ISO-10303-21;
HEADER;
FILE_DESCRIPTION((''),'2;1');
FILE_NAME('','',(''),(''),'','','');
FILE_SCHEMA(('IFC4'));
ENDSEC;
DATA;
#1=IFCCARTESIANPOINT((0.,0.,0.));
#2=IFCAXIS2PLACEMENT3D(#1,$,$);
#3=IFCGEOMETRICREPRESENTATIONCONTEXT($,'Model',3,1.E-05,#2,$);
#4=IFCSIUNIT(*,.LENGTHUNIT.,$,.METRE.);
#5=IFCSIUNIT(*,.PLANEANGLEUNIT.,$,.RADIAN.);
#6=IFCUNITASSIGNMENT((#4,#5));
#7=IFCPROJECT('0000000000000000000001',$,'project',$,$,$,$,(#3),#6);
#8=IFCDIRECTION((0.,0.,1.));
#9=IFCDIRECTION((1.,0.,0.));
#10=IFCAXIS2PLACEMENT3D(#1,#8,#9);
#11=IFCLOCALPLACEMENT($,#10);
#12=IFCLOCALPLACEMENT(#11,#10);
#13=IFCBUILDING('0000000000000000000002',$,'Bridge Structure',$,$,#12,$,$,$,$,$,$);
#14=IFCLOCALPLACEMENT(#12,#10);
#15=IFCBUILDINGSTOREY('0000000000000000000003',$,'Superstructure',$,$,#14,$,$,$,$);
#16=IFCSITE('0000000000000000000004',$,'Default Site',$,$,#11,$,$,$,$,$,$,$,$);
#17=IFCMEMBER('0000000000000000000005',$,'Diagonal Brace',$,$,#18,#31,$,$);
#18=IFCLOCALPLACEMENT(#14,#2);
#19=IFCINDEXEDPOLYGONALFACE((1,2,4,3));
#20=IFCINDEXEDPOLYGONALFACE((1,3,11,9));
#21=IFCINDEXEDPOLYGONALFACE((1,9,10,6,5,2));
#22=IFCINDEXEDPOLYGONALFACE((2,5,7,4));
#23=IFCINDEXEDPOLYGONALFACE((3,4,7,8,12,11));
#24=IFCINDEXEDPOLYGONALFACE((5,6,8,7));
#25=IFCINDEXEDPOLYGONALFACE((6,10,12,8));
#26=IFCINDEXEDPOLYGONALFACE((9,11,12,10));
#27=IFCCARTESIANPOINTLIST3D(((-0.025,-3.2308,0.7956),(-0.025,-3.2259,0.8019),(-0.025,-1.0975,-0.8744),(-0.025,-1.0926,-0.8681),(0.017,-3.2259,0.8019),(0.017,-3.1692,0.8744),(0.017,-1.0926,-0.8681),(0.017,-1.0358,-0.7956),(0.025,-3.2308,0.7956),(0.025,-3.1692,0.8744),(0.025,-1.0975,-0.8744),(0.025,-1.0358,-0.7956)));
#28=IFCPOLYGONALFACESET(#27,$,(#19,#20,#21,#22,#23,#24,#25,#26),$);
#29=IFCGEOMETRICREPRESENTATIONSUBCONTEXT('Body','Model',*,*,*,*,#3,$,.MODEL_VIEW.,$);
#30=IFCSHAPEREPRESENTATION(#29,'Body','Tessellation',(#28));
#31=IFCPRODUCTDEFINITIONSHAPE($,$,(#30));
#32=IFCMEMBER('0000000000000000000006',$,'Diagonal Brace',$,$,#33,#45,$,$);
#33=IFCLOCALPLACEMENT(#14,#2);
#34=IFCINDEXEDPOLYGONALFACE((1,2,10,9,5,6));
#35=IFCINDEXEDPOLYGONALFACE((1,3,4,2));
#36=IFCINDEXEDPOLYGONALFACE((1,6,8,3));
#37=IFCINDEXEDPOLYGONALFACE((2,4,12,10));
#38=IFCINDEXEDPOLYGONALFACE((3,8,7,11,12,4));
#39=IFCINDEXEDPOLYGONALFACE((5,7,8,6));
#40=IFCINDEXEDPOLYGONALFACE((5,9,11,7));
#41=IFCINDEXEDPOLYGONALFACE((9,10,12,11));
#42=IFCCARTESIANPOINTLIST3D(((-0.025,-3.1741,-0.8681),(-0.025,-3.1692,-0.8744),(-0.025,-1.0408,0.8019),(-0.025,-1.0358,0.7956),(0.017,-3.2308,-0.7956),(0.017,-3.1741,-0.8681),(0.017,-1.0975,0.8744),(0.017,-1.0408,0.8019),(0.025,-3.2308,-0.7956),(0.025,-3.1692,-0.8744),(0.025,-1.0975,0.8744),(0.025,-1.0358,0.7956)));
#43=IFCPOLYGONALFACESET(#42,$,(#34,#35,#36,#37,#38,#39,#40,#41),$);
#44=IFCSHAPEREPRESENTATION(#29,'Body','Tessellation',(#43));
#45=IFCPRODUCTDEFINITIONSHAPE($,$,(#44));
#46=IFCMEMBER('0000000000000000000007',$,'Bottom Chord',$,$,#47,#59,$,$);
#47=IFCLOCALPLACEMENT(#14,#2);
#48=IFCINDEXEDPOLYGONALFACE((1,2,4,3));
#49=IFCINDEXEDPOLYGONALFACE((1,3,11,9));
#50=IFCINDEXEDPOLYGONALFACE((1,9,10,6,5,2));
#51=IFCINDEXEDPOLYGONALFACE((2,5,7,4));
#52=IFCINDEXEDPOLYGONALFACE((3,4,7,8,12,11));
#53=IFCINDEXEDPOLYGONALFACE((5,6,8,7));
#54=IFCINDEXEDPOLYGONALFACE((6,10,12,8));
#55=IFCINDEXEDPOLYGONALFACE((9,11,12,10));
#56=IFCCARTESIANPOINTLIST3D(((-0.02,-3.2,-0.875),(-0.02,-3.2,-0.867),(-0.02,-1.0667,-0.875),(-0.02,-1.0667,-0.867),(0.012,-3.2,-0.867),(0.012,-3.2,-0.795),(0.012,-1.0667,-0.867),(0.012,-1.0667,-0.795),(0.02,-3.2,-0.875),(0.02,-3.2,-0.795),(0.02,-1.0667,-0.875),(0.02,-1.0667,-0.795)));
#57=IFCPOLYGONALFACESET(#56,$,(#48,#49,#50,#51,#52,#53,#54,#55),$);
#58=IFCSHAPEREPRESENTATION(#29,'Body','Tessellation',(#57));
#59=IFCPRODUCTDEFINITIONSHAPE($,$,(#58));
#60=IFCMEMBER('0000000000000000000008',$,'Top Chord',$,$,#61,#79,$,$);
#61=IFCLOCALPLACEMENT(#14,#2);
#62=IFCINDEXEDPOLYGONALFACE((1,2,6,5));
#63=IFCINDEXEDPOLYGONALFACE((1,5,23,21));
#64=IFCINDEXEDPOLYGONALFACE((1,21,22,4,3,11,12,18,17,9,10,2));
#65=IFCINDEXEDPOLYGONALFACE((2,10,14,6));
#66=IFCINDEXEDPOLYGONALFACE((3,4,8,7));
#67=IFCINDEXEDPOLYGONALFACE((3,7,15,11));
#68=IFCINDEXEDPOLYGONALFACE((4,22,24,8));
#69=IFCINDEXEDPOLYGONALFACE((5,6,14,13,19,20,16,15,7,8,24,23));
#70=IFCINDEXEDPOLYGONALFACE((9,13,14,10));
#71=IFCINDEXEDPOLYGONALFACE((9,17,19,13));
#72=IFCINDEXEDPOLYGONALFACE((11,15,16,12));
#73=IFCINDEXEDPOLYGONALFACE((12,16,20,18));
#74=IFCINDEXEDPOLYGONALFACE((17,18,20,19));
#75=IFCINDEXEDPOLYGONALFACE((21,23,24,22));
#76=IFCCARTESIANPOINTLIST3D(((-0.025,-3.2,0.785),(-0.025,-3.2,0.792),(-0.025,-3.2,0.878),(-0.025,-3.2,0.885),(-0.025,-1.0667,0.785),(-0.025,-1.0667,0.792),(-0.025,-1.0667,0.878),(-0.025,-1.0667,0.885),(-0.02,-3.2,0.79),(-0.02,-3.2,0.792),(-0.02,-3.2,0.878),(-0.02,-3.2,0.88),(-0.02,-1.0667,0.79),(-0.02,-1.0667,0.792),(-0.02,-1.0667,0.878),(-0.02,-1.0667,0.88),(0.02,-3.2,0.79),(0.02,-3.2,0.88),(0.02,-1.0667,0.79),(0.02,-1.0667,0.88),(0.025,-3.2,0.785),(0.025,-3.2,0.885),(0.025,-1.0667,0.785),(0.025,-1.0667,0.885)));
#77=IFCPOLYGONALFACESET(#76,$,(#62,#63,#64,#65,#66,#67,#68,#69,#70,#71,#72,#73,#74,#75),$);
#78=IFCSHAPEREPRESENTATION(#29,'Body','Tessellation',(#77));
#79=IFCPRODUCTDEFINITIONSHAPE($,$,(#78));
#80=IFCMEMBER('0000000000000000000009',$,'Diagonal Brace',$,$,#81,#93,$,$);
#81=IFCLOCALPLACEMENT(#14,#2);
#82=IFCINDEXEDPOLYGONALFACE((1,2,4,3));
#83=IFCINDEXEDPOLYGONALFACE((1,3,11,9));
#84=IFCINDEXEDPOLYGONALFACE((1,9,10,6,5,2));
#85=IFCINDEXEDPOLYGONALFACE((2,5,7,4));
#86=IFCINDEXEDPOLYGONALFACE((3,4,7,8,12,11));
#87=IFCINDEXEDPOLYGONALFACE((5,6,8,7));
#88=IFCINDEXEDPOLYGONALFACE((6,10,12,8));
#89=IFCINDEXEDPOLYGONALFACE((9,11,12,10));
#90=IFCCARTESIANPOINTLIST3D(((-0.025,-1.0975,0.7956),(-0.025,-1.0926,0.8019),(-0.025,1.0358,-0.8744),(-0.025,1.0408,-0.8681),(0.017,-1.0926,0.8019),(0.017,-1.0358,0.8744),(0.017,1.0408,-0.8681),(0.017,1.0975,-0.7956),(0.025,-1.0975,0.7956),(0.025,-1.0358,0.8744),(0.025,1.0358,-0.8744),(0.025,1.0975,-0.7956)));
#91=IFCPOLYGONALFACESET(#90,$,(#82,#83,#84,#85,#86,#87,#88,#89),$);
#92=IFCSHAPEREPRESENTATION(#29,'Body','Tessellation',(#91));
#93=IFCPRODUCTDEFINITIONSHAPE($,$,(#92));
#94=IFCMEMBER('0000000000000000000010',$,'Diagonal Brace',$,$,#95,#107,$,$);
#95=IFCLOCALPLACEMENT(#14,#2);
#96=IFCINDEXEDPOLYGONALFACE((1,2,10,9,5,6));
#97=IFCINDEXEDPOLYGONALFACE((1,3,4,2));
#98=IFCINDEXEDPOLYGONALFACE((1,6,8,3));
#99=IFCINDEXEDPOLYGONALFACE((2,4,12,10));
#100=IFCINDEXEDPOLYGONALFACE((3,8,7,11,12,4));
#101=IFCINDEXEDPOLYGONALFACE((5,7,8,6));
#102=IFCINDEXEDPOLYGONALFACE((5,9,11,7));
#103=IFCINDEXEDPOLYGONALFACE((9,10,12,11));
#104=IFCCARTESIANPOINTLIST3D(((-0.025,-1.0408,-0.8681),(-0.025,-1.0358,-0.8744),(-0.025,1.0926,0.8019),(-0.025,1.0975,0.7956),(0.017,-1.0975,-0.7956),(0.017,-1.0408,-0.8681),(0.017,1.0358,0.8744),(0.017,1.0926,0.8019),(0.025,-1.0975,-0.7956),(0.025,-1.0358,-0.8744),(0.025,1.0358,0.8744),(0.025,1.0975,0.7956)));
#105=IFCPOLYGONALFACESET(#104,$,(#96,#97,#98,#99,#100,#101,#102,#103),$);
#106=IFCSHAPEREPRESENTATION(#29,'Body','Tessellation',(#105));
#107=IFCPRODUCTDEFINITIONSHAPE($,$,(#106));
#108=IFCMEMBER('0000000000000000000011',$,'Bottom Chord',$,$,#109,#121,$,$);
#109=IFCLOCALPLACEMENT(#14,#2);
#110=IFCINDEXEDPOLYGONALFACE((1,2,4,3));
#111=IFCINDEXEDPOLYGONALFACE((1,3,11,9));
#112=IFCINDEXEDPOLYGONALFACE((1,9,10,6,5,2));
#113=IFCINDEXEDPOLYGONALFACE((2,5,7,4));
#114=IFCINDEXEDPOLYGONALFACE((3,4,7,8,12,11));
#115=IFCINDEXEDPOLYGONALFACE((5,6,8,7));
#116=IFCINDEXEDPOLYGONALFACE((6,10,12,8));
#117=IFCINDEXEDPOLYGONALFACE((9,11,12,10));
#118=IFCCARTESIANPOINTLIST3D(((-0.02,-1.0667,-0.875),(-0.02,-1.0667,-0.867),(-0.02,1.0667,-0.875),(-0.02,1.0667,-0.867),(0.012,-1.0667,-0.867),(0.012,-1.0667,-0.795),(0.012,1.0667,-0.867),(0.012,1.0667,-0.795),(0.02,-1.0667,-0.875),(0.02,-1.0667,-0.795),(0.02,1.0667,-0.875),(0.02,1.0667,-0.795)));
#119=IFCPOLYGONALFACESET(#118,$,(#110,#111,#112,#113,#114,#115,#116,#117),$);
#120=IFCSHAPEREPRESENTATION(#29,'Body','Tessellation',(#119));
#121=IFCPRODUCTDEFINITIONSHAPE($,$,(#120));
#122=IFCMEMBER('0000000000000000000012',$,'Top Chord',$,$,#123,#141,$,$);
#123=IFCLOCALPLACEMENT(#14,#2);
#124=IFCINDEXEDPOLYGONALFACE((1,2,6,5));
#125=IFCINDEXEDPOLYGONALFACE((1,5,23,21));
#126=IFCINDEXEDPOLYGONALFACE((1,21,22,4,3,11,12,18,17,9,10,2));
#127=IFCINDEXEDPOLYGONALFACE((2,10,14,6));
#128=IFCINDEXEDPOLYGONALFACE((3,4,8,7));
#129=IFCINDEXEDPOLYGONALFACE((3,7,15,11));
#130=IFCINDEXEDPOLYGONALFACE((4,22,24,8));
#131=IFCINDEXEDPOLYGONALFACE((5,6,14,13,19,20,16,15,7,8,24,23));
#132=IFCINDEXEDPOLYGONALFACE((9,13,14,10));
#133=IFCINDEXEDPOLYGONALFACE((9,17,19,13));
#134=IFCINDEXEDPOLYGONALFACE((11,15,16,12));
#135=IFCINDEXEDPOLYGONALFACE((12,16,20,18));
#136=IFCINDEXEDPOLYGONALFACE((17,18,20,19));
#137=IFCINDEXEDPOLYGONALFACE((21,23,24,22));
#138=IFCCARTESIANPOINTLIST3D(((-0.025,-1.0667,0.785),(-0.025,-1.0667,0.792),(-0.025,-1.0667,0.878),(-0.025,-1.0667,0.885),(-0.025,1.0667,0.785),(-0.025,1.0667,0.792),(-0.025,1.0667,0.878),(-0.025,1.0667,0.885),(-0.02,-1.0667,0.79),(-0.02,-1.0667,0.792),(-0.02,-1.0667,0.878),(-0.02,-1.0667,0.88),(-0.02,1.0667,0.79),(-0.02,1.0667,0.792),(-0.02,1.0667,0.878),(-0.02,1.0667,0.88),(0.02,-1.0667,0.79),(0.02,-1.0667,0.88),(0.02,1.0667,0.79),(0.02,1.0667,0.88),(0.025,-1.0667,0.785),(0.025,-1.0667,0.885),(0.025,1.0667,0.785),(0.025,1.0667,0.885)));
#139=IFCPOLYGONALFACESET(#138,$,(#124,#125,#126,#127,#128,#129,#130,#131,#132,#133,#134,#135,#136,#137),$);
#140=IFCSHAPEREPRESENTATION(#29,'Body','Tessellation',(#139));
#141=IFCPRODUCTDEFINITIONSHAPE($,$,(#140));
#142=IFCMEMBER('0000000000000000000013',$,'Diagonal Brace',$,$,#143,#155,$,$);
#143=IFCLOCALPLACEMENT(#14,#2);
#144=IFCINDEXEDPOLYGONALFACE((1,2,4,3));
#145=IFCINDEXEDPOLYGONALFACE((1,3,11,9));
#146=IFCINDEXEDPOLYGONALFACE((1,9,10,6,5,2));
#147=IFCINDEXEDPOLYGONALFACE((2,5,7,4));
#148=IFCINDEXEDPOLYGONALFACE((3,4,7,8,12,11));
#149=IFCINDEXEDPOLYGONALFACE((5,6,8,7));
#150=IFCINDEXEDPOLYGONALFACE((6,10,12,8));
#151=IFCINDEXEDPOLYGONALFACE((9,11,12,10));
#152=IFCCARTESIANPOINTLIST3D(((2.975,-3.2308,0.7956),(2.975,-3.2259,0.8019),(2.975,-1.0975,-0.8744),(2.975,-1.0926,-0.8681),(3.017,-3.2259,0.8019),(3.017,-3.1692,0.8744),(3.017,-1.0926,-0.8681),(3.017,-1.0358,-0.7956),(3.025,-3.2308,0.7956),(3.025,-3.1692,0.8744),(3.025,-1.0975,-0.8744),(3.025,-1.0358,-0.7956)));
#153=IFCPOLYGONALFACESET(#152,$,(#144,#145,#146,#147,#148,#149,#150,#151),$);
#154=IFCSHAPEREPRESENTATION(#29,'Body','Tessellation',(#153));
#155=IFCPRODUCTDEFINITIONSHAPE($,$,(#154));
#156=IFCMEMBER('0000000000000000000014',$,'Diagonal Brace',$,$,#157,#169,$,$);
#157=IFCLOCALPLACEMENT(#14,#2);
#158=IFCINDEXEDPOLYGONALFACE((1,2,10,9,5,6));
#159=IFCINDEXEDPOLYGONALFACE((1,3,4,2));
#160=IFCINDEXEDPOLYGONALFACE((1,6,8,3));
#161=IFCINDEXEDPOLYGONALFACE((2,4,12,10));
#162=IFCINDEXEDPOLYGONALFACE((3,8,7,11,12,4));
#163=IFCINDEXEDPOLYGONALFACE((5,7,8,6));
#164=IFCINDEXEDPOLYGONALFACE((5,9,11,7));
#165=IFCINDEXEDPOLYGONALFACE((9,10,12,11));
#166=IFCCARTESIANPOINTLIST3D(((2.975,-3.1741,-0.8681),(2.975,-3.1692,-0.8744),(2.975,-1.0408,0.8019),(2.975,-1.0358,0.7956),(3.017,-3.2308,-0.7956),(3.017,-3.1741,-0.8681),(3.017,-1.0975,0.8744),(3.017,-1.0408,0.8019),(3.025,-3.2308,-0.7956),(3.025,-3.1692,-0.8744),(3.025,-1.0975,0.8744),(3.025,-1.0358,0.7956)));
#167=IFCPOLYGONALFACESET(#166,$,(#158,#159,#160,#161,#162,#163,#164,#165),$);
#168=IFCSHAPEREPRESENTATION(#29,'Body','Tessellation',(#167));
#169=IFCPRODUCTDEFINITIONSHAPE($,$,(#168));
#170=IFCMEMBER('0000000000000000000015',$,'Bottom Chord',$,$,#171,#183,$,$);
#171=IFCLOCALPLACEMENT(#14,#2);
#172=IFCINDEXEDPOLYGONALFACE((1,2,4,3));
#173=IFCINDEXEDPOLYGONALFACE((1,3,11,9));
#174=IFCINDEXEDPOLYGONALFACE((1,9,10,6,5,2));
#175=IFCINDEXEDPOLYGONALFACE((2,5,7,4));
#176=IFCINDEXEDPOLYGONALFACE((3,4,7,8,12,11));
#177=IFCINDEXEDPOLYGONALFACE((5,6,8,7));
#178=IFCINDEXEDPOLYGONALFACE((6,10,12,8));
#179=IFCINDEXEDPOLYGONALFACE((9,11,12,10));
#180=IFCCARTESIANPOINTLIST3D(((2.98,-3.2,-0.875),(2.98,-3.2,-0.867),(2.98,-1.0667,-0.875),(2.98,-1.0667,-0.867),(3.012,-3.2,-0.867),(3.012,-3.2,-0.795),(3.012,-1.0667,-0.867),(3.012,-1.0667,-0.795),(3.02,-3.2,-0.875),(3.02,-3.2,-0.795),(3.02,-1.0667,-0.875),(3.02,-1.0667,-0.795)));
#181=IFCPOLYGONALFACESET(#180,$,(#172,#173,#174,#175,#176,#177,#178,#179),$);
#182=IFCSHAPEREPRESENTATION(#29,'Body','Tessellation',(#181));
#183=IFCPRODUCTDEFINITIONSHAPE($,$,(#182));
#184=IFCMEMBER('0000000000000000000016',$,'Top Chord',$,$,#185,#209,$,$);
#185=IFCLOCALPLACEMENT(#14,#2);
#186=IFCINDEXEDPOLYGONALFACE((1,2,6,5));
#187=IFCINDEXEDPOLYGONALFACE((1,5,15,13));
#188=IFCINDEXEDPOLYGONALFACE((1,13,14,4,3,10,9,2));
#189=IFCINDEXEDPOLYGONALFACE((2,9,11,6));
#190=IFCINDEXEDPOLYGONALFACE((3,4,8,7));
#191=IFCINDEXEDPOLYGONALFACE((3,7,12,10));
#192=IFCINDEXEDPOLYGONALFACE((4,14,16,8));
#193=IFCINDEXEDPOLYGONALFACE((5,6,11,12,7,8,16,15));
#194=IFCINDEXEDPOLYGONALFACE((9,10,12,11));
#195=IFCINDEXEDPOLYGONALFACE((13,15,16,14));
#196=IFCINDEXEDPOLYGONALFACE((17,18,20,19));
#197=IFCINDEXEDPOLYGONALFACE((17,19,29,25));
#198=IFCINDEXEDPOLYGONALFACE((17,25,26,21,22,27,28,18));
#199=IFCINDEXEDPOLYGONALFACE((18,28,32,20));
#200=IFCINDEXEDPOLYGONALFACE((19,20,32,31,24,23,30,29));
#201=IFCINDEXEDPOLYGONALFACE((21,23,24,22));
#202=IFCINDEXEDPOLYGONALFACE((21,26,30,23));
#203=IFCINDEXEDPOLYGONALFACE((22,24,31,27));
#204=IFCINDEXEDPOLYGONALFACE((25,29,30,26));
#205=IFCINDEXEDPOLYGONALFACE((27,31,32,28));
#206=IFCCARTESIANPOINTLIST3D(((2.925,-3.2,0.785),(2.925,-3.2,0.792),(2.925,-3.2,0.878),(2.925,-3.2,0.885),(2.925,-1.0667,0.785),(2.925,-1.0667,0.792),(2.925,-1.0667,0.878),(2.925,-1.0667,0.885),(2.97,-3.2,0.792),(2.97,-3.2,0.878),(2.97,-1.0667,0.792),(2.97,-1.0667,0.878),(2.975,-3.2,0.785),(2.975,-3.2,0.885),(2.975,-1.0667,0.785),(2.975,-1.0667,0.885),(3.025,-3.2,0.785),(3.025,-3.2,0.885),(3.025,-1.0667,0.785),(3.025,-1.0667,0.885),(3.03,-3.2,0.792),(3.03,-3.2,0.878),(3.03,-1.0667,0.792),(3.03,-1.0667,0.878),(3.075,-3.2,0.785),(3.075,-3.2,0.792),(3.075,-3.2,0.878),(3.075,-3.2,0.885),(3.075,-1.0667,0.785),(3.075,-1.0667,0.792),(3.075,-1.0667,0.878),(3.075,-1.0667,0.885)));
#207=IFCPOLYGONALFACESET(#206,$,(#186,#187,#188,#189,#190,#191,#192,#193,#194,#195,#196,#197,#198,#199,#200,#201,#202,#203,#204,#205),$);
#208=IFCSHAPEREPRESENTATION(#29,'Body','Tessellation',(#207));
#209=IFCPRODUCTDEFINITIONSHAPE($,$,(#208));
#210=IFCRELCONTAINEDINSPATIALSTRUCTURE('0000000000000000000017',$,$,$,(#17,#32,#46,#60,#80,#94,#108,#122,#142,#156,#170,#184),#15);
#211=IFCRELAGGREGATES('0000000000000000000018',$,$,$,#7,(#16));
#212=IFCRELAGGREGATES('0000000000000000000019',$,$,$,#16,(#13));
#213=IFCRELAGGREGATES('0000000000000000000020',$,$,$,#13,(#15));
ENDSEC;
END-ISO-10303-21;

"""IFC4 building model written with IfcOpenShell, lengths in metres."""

from ifc_helpers import new_model, si_unit, frame, origin, origin_with_axes, origin_2d_with_axis, place, context, subcontext, project, spatial, polyline, l_section, c_section, outline, composite_profile, extrude, element, save


model = new_model("IFC4")

# Units and contexts
model_context = context("Model", 3, precision=1e-05, world=origin())
body_context = subcontext(model_context, "Body", "Model", "MODEL_VIEW")
ifc_project = project(units=[si_unit("LENGTHUNIT", "METRE"), si_unit("PLANEANGLEUNIT", "RADIAN")], contexts=[model_context])

# Site, building, storey
site_placement = place(None, origin_with_axes())
site = spatial("IfcSite", under=ifc_project, at=site_placement, Name="Default Site")
building_placement = place(site_placement, origin_with_axes())
building = spatial("IfcBuilding", under=site, at=building_placement, Name="Bridge Structure")
storey_placement = place(building_placement, origin_with_axes())
storey = spatial("IfcBuildingStorey", under=building, at=storey_placement, Name="Superstructure")

# Members
for number, where, z_axis, x_axis, name in (
    (1, (0.0, -3.2, 0.835), (0.0, 0.787427, -0.616408), (-1.0, 0.0, 0.0), "Diagonal Brace"),
    (2, (0.0, -3.2, -0.835), (0.0, 0.787427, 0.616408), (-1.0, 0.0, 0.0), "Diagonal Brace"),
):
    element("IfcMember", number, at=place(storey_placement, frame(where, z_axis=z_axis, x_axis=x_axis)), inside=storey, Name=name, context=body_context, shape_type="SweptSolid", body=[
        extrude(l_section(Depth=0.1, Width=0.05, Thickness=0.008, at=origin_2d_with_axis()), origin_with_axes(), (0.0, 0.0, 1.0), 2.7092),
    ])
member_1_placement = place(storey_placement, frame((0.0, -3.2, -0.835), z_axis=(0.0, 1.0, 0.0), x_axis=(-1.0, 0.0, 0.0)))
element("IfcMember", 3, at=member_1_placement, inside=storey, Name="Bottom Chord", context=body_context, shape_type="SweptSolid", body=[
    extrude(l_section(Depth=0.08, Width=0.04, Thickness=0.008, at=origin_2d_with_axis()), origin_with_axes(), (0.0, 0.0, 1.0), 2.1333),
])
member_2_placement = place(storey_placement, frame((0.0, -3.2, 0.835), z_axis=(0.0, 1.0, 0.0), x_axis=(-1.0, 0.0, 0.0)))
element("IfcMember", 4, at=member_2_placement, inside=storey, Name="Top Chord", context=body_context, shape_type="SweptSolid", body=[
    extrude(c_section(Depth=0.1, Width=0.05, WallThickness=0.005, Girth=0.007, at=origin_2d_with_axis()), origin_with_axes(), (0.0, 0.0, 1.0), 2.1333),
])
for number, where, z_axis, x_axis, name in (
    (5, (0.0, -1.0667, 0.835), (0.0, 0.787427, -0.616408), (-1.0, 0.0, 0.0), "Diagonal Brace"),
    (6, (0.0, -1.0667, -0.835), (0.0, 0.787427, 0.616408), (-1.0, 0.0, 0.0), "Diagonal Brace"),
):
    element("IfcMember", number, at=place(storey_placement, frame(where, z_axis=z_axis, x_axis=x_axis)), inside=storey, Name=name, context=body_context, shape_type="SweptSolid", body=[
        extrude(l_section(Depth=0.1, Width=0.05, Thickness=0.008, at=origin_2d_with_axis()), origin_with_axes(), (0.0, 0.0, 1.0), 2.7092),
    ])
member_3_placement = place(storey_placement, frame((0.0, -1.0667, -0.835), z_axis=(0.0, 1.0, 0.0), x_axis=(-1.0, 0.0, 0.0)))
element("IfcMember", 7, at=member_3_placement, inside=storey, Name="Bottom Chord", context=body_context, shape_type="SweptSolid", body=[
    extrude(l_section(Depth=0.08, Width=0.04, Thickness=0.008, at=origin_2d_with_axis()), origin_with_axes(), (0.0, 0.0, 1.0), 2.1333),
])
member_4_placement = place(storey_placement, frame((0.0, -1.0667, 0.835), z_axis=(0.0, 1.0, 0.0), x_axis=(-1.0, 0.0, 0.0)))
element("IfcMember", 8, at=member_4_placement, inside=storey, Name="Top Chord", context=body_context, shape_type="SweptSolid", body=[
    extrude(c_section(Depth=0.1, Width=0.05, WallThickness=0.005, Girth=0.007, at=origin_2d_with_axis()), origin_with_axes(), (0.0, 0.0, 1.0), 2.1333),
])
for number, where, z_axis, x_axis, name in (
    (9, (3.0, -3.2, 0.835), (0.0, 0.787427, -0.616408), (-1.0, 0.0, 0.0), "Diagonal Brace"),
    (10, (3.0, -3.2, -0.835), (0.0, 0.787427, 0.616408), (-1.0, 0.0, 0.0), "Diagonal Brace"),
):
    element("IfcMember", number, at=place(storey_placement, frame(where, z_axis=z_axis, x_axis=x_axis)), inside=storey, Name=name, context=body_context, shape_type="SweptSolid", body=[
        extrude(l_section(Depth=0.1, Width=0.05, Thickness=0.008, at=origin_2d_with_axis()), origin_with_axes(), (0.0, 0.0, 1.0), 2.7092),
    ])
member_5_placement = place(storey_placement, frame((3.0, -3.2, -0.835), z_axis=(0.0, 1.0, 0.0), x_axis=(-1.0, 0.0, 0.0)))
element("IfcMember", 11, at=member_5_placement, inside=storey, Name="Bottom Chord", context=body_context, shape_type="SweptSolid", body=[
    extrude(l_section(Depth=0.08, Width=0.04, Thickness=0.008, at=origin_2d_with_axis()), origin_with_axes(), (0.0, 0.0, 1.0), 2.1333),
])
member_6_placement = place(storey_placement, frame((3.0, -3.2, 0.835), z_axis=(0.0, 1.0, 0.0), x_axis=(-1.0, 0.0, 0.0)))
element("IfcMember", 12, at=member_6_placement, inside=storey, Name="Top Chord", context=body_context, shape_type="SweptSolid", body=[
    extrude(composite_profile([outline(polyline([(-0.025, -0.05), (-0.025, 0.05), (-0.075, 0.05), (-0.075, 0.043), (-0.03, 0.043), (-0.03, -0.043), (-0.075, -0.043), (-0.075, -0.05), (-0.025, -0.05)])), outline(polyline([(0.025, -0.05), (0.075, -0.05), (0.075, -0.043), (0.03, -0.043), (0.03, 0.043), (0.075, 0.043), (0.075, 0.05), (0.025, 0.05), (0.025, -0.05)]))]), origin_with_axes(), (0.0, 0.0, 1.0), 2.1333),
])

save(model, "model.ifc")
